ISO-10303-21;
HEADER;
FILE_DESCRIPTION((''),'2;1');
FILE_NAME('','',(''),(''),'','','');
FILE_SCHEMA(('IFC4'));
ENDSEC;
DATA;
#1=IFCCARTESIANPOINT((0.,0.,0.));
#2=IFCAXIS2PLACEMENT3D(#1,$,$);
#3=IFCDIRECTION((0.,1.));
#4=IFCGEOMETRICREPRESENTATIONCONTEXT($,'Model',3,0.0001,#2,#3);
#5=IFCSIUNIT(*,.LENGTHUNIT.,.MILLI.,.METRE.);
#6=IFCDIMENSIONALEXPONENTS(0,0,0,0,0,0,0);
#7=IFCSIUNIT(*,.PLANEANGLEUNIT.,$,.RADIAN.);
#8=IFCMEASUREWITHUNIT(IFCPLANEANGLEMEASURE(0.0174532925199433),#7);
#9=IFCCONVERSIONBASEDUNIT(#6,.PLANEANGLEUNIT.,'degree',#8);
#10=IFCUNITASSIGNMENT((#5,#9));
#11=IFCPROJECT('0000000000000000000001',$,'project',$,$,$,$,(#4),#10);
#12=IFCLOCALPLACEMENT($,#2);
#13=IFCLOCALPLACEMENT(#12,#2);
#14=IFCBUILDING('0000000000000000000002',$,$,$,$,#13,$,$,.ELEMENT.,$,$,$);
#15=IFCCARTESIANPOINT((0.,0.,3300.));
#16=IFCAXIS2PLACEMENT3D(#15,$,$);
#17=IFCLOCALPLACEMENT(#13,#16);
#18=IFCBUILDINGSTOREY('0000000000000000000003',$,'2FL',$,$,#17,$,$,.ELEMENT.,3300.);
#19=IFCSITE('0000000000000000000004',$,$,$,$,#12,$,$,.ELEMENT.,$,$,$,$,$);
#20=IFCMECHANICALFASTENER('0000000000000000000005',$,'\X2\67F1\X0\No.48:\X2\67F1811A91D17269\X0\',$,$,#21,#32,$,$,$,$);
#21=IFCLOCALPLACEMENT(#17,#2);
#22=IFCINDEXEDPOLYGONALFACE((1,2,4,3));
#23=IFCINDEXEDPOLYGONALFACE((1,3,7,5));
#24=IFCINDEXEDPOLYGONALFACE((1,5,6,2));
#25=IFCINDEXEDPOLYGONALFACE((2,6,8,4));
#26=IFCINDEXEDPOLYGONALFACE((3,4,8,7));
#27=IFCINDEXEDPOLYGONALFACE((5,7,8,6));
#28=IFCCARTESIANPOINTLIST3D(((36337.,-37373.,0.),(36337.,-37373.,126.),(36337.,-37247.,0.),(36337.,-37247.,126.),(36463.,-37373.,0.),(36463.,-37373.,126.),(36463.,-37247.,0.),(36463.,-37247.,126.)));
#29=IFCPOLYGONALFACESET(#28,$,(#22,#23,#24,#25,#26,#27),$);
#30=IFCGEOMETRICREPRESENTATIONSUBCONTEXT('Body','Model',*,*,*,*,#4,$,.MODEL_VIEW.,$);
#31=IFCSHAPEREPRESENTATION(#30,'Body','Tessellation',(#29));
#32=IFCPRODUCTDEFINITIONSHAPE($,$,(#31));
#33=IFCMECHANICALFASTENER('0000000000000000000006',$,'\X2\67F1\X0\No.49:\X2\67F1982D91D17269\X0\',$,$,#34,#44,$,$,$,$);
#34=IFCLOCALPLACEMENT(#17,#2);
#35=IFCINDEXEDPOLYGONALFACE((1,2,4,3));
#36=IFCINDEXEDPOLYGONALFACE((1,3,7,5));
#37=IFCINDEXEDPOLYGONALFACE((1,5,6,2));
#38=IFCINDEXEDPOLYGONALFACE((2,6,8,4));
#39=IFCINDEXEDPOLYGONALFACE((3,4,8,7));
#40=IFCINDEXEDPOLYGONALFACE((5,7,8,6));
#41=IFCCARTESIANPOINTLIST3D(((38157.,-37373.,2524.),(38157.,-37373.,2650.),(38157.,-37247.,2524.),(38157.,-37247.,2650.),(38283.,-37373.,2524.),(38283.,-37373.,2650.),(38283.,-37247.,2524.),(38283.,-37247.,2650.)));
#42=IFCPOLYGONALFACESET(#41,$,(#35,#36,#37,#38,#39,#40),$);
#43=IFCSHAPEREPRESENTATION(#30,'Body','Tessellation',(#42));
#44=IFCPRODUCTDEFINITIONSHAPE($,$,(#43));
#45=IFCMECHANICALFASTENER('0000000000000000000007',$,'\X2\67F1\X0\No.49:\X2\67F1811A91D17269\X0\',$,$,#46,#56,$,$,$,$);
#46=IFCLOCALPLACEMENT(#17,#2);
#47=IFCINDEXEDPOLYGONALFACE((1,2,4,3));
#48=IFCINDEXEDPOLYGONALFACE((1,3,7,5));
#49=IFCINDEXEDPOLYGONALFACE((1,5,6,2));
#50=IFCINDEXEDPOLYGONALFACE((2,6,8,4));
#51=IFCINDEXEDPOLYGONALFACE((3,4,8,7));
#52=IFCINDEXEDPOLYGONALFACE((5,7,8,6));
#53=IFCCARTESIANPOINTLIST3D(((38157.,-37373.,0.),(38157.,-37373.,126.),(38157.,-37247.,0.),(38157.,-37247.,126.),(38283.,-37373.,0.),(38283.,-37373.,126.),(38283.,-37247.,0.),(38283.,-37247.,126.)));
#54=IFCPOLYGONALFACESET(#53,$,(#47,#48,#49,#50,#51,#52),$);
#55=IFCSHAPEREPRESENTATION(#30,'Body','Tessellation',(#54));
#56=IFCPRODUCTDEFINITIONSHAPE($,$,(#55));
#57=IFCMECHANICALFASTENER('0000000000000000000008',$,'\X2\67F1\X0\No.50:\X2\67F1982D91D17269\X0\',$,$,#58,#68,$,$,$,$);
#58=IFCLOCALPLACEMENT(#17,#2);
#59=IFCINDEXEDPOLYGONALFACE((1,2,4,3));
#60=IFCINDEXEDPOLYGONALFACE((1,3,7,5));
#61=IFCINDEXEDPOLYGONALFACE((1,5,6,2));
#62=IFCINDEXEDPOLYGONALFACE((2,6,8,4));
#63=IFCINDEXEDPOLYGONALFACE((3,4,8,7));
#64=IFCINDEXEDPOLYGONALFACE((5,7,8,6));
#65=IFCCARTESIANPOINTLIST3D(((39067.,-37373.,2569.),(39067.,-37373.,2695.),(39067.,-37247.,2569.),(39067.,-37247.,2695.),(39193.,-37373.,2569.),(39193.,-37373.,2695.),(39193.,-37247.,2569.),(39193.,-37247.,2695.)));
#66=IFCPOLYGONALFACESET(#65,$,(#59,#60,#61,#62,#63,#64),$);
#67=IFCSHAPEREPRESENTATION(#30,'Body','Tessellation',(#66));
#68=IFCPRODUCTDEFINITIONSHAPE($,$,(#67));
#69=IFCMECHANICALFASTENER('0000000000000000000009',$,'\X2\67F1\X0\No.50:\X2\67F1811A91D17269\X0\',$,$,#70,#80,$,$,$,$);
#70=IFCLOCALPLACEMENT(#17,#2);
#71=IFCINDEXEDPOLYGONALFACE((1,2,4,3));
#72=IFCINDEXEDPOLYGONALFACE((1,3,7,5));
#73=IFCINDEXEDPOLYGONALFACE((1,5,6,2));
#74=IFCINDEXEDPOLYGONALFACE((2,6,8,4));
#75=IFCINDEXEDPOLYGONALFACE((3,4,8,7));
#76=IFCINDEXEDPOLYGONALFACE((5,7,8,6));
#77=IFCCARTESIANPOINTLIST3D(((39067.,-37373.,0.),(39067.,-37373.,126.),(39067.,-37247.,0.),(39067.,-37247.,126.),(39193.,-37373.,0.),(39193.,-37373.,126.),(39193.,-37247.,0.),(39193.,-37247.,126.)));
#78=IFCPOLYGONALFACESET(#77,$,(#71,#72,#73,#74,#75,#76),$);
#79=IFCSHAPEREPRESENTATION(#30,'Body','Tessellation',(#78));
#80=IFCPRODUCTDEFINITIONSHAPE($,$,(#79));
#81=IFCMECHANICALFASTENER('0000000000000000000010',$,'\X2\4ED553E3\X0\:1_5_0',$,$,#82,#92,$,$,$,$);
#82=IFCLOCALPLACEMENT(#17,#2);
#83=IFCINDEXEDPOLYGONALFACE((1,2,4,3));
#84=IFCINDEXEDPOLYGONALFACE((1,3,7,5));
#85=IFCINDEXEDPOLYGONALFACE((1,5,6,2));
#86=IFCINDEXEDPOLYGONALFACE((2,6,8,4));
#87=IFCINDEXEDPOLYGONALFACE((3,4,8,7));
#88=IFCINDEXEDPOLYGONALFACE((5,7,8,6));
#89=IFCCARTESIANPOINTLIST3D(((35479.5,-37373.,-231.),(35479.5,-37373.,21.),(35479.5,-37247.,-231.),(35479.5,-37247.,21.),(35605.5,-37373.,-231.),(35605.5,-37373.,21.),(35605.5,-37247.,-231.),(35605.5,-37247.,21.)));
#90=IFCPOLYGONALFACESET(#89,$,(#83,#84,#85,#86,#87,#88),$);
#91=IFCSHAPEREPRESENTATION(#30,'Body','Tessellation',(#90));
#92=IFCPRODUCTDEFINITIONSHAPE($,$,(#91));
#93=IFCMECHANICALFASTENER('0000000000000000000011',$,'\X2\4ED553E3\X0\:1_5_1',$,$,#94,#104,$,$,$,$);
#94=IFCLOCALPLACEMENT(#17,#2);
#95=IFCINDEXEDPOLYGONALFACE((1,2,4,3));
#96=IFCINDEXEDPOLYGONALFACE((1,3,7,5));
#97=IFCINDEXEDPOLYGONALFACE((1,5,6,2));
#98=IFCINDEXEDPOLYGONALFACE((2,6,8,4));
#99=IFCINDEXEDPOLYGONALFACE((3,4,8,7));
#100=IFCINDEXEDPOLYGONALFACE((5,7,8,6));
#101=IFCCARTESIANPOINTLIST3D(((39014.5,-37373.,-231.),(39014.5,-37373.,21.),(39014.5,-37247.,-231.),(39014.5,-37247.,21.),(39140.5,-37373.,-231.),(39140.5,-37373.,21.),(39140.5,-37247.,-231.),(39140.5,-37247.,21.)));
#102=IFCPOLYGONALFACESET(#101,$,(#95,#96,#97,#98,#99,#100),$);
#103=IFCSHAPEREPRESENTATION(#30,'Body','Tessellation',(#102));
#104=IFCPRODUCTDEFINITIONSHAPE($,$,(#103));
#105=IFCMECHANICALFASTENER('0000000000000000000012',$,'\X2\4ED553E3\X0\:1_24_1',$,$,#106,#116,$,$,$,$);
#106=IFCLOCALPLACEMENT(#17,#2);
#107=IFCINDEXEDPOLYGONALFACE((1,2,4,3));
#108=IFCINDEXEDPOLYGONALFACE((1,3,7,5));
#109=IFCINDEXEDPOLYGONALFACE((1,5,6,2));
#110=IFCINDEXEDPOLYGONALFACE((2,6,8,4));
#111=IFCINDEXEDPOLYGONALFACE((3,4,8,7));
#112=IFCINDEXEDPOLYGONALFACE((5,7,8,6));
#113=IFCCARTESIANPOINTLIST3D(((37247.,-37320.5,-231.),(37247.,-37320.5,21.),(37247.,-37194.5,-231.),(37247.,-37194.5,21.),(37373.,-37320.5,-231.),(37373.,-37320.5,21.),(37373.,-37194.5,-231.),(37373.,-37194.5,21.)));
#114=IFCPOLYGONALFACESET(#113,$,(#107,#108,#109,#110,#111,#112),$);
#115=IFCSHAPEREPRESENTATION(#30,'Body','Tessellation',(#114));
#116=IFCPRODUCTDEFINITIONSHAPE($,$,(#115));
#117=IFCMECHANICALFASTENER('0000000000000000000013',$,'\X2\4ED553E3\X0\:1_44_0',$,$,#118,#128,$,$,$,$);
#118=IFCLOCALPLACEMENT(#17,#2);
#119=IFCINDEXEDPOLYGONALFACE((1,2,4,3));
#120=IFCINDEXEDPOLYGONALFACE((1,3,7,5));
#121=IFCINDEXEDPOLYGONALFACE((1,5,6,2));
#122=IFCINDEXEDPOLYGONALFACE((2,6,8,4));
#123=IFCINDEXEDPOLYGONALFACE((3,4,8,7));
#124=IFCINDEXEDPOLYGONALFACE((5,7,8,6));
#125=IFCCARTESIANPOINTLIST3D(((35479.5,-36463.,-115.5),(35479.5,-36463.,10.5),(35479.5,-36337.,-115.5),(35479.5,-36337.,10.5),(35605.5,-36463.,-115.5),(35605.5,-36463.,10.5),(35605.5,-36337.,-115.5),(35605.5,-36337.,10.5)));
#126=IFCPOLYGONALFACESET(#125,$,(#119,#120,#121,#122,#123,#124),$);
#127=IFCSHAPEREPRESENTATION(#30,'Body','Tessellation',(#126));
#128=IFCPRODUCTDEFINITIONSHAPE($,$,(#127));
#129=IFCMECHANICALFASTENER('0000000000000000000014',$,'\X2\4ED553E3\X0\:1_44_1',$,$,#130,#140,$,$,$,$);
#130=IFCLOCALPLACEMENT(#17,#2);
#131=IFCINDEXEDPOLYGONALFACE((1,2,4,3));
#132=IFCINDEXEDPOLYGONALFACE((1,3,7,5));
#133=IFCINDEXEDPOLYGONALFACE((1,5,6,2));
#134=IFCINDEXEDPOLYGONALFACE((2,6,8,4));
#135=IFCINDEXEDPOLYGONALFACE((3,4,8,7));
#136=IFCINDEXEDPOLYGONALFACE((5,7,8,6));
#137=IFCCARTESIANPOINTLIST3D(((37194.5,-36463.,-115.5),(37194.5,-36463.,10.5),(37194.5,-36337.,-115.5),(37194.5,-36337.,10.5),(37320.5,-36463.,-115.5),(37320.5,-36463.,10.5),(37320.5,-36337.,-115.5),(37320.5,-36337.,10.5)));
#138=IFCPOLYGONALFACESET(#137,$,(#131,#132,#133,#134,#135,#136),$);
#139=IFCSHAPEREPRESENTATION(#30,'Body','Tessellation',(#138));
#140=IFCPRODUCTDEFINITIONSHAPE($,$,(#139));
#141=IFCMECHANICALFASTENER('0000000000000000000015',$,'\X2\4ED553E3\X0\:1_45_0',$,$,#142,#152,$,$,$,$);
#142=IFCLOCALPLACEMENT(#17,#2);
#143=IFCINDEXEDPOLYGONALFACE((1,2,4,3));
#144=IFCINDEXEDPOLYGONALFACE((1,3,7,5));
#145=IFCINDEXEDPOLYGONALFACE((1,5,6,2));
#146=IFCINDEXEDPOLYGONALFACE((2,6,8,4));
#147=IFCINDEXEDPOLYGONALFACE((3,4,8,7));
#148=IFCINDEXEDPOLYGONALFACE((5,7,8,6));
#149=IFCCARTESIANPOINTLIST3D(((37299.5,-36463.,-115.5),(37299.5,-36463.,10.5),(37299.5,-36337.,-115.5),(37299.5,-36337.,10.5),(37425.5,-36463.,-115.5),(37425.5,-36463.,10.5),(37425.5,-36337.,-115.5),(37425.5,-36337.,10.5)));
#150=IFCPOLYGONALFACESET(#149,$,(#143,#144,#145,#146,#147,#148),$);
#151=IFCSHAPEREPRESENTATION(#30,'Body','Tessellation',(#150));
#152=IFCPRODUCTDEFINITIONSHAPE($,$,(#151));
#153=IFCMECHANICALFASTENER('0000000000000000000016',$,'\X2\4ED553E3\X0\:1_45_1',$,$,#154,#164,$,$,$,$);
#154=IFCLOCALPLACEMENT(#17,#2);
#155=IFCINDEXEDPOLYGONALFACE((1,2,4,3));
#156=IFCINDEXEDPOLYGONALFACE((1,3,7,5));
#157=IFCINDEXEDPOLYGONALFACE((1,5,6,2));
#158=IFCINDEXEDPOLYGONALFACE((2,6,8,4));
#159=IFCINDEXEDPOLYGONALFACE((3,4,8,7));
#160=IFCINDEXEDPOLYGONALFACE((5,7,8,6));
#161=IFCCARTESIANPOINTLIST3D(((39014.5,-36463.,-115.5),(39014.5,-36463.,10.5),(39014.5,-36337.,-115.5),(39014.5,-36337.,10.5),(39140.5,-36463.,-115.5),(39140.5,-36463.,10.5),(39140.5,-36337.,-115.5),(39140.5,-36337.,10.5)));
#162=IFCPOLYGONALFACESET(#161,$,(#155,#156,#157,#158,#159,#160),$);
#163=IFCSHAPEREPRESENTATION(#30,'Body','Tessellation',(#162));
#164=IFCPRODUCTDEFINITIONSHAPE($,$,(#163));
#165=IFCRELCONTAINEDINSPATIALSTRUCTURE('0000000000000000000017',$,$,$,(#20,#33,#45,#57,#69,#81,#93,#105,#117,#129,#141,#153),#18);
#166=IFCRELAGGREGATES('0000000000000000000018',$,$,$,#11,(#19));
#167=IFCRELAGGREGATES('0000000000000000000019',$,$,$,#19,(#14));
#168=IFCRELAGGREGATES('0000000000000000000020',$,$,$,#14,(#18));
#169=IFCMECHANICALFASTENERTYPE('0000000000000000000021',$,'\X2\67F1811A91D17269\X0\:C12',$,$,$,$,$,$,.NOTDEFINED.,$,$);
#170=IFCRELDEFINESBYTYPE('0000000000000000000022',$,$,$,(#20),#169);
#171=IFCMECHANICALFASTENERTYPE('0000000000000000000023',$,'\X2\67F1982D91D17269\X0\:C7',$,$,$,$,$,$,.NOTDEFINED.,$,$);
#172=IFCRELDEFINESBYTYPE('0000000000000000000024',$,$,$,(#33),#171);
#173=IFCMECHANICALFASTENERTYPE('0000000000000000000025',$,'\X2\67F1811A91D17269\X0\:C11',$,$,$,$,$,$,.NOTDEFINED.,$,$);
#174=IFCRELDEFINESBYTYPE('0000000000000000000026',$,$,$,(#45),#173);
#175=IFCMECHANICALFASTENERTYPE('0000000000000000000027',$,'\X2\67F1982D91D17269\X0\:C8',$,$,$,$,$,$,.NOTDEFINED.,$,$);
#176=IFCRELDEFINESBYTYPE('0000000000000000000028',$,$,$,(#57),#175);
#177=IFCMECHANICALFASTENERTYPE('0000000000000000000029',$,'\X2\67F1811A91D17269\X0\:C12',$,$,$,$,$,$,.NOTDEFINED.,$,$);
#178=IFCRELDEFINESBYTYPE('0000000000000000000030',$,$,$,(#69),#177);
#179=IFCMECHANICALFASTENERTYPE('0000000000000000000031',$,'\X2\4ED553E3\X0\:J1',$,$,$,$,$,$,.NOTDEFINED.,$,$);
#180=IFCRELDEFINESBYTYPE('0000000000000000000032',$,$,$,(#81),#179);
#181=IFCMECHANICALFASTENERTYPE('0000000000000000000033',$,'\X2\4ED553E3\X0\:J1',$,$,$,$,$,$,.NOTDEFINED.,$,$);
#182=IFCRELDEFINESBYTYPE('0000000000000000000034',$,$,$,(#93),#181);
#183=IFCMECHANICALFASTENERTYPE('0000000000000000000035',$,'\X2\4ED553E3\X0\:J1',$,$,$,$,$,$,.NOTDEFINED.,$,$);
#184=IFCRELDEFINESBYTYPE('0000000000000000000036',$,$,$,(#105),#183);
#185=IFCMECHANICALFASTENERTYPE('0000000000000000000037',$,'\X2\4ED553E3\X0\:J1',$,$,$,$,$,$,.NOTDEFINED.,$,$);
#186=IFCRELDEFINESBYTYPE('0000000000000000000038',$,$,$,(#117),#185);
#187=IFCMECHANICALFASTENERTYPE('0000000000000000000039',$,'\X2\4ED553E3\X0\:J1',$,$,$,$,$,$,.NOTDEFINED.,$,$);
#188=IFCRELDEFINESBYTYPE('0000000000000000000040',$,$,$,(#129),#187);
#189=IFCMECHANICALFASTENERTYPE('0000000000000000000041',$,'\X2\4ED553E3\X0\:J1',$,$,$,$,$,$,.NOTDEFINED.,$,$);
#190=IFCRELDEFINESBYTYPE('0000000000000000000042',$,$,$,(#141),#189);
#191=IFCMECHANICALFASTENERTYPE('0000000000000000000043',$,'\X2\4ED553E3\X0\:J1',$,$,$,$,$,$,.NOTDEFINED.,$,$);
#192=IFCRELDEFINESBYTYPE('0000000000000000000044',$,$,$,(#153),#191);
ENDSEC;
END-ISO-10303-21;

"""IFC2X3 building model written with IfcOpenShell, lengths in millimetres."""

from ifc_helpers import new_model, entity, si_unit, converted_unit, direction, frame, origin, origin_with_axes, origin_2d, place, context, subcontext, project, spatial, rectangle, extrude, type_object, element, save


model = new_model("IFC2X3")

# Units and contexts
model_context = context("Model", 3, precision=0.0001, world=origin(), true_north=direction((0.0, 1.0)))
body_context = subcontext(model_context, "Body", "Model", "MODEL_VIEW")
ifc_project = project(units=[si_unit("LENGTHUNIT", "METRE", prefix="MILLI"), converted_unit("PLANEANGLEUNIT", "degree", entity("IfcPlaneAngleMeasure", 0.0174532925199433), si_unit("PLANEANGLEUNIT", "RADIAN"), dimensions=[0, 0, 0, 0, 0, 0, 0])], contexts=[model_context])

# Site, building, storey
site_placement = place(None, origin())
site = spatial("IfcSite", under=ifc_project, at=site_placement, CompositionType="ELEMENT")
building_placement = place(site_placement, origin())
building = spatial("IfcBuilding", under=site, at=building_placement, CompositionType="ELEMENT")
storey_placement = place(building_placement, frame((0.0, 0.0, 3300.0)))
storey = spatial("IfcBuildingStorey", under=building, at=storey_placement, Name="2FL", CompositionType="ELEMENT", Elevation=3300.0)

# Mechanical fasteners
mechanical_fastener_type_1 = type_object("IfcMechanicalFastenerType", Name="柱脚金物:C12")
mechanical_fastener_1_placement = place(storey_placement, frame((36400.0, -37310.0, 0.0)))
element("IfcMechanicalFastener", 1, at=mechanical_fastener_1_placement, inside=storey, type_object=mechanical_fastener_type_1, Name="柱No.48:柱脚金物", context=body_context, shape_type="SweptSolid", body=[
    extrude(rectangle(XDim=126.0, YDim=126.0, at=origin_2d()), origin_with_axes(), (0.0, 0.0, 1.0), 126.0),
])
mechanical_fastener_type_2 = type_object("IfcMechanicalFastenerType", Name="柱頭金物:C7")
mechanical_fastener_2_placement = place(storey_placement, frame((38220.0, -37310.0, 2524.0)))
element("IfcMechanicalFastener", 2, at=mechanical_fastener_2_placement, inside=storey, type_object=mechanical_fastener_type_2, Name="柱No.49:柱頭金物", context=body_context, shape_type="SweptSolid", body=[
    extrude(rectangle(XDim=126.0, YDim=126.0, at=origin_2d()), origin_with_axes(), (0.0, 0.0, 1.0), 126.0),
])
mechanical_fastener_type_3 = type_object("IfcMechanicalFastenerType", Name="柱脚金物:C11")
mechanical_fastener_3_placement = place(storey_placement, frame((38220.0, -37310.0, 0.0)))
element("IfcMechanicalFastener", 3, at=mechanical_fastener_3_placement, inside=storey, type_object=mechanical_fastener_type_3, Name="柱No.49:柱脚金物", context=body_context, shape_type="SweptSolid", body=[
    extrude(rectangle(XDim=126.0, YDim=126.0, at=origin_2d()), origin_with_axes(), (0.0, 0.0, 1.0), 126.0),
])
mechanical_fastener_type_4 = type_object("IfcMechanicalFastenerType", Name="柱頭金物:C8")
mechanical_fastener_4_placement = place(storey_placement, frame((39130.0, -37310.0, 2569.0)))
element("IfcMechanicalFastener", 4, at=mechanical_fastener_4_placement, inside=storey, type_object=mechanical_fastener_type_4, Name="柱No.50:柱頭金物", context=body_context, shape_type="SweptSolid", body=[
    extrude(rectangle(XDim=126.0, YDim=126.0, at=origin_2d()), origin_with_axes(), (0.0, 0.0, 1.0), 126.0),
])
mechanical_fastener_type_5 = type_object("IfcMechanicalFastenerType", Name="柱脚金物:C12")
mechanical_fastener_5_placement = place(storey_placement, frame((39130.0, -37310.0, 0.0)))
element("IfcMechanicalFastener", 5, at=mechanical_fastener_5_placement, inside=storey, type_object=mechanical_fastener_type_5, Name="柱No.50:柱脚金物", context=body_context, shape_type="SweptSolid", body=[
    extrude(rectangle(XDim=126.0, YDim=126.0, at=origin_2d()), origin_with_axes(), (0.0, 0.0, 1.0), 126.0),
])
mechanical_fastener_type_6 = type_object("IfcMechanicalFastenerType", Name="仕口:J1")
mechanical_fastener_6_placement = place(storey_placement, frame((35542.5, -37310.0, -231.0)))
element("IfcMechanicalFastener", 6, at=mechanical_fastener_6_placement, inside=storey, type_object=mechanical_fastener_type_6, Name="仕口:1_5_0", context=body_context, shape_type="SweptSolid", body=[
    extrude(rectangle(XDim=126.0, YDim=126.0, at=origin_2d()), origin_with_axes(), (0.0, 0.0, 1.0), 252.0),
])
mechanical_fastener_type_7 = type_object("IfcMechanicalFastenerType", Name="仕口:J1")
mechanical_fastener_7_placement = place(storey_placement, frame((39077.5, -37310.0, -231.0)))
element("IfcMechanicalFastener", 7, at=mechanical_fastener_7_placement, inside=storey, type_object=mechanical_fastener_type_7, Name="仕口:1_5_1", context=body_context, shape_type="SweptSolid", body=[
    extrude(rectangle(XDim=126.0, YDim=126.0, at=origin_2d()), origin_with_axes(), (0.0, 0.0, 1.0), 252.0),
])
mechanical_fastener_type_8 = type_object("IfcMechanicalFastenerType", Name="仕口:J1")
mechanical_fastener_8_placement = place(storey_placement, frame((37310.0, -37257.5, -231.0)))
element("IfcMechanicalFastener", 8, at=mechanical_fastener_8_placement, inside=storey, type_object=mechanical_fastener_type_8, Name="仕口:1_24_1", context=body_context, shape_type="SweptSolid", body=[
    extrude(rectangle(XDim=126.0, YDim=126.0, at=origin_2d()), origin_with_axes(), (0.0, 0.0, 1.0), 252.0),
])
mechanical_fastener_type_9 = type_object("IfcMechanicalFastenerType", Name="仕口:J1")
mechanical_fastener_9_placement = place(storey_placement, frame((35542.5, -36400.0, -115.5)))
element("IfcMechanicalFastener", 9, at=mechanical_fastener_9_placement, inside=storey, type_object=mechanical_fastener_type_9, Name="仕口:1_44_0", context=body_context, shape_type="SweptSolid", body=[
    extrude(rectangle(XDim=126.0, YDim=126.0, at=origin_2d()), origin_with_axes(), (0.0, 0.0, 1.0), 126.0),
])
mechanical_fastener_type_10 = type_object("IfcMechanicalFastenerType", Name="仕口:J1")
mechanical_fastener_10_placement = place(storey_placement, frame((37257.5, -36400.0, -115.5)))
element("IfcMechanicalFastener", 10, at=mechanical_fastener_10_placement, inside=storey, type_object=mechanical_fastener_type_10, Name="仕口:1_44_1", context=body_context, shape_type="SweptSolid", body=[
    extrude(rectangle(XDim=126.0, YDim=126.0, at=origin_2d()), origin_with_axes(), (0.0, 0.0, 1.0), 126.0),
])
mechanical_fastener_type_11 = type_object("IfcMechanicalFastenerType", Name="仕口:J1")
mechanical_fastener_11_placement = place(storey_placement, frame((37362.5, -36400.0, -115.5)))
element("IfcMechanicalFastener", 11, at=mechanical_fastener_11_placement, inside=storey, type_object=mechanical_fastener_type_11, Name="仕口:1_45_0", context=body_context, shape_type="SweptSolid", body=[
    extrude(rectangle(XDim=126.0, YDim=126.0, at=origin_2d()), origin_with_axes(), (0.0, 0.0, 1.0), 126.0),
])
mechanical_fastener_type_12 = type_object("IfcMechanicalFastenerType", Name="仕口:J1")
mechanical_fastener_12_placement = place(storey_placement, frame((39077.5, -36400.0, -115.5)))
element("IfcMechanicalFastener", 12, at=mechanical_fastener_12_placement, inside=storey, type_object=mechanical_fastener_type_12, Name="仕口:1_45_1", context=body_context, shape_type="SweptSolid", body=[
    extrude(rectangle(XDim=126.0, YDim=126.0, at=origin_2d()), origin_with_axes(), (0.0, 0.0, 1.0), 126.0),
])

save(model, "model.ifc")
